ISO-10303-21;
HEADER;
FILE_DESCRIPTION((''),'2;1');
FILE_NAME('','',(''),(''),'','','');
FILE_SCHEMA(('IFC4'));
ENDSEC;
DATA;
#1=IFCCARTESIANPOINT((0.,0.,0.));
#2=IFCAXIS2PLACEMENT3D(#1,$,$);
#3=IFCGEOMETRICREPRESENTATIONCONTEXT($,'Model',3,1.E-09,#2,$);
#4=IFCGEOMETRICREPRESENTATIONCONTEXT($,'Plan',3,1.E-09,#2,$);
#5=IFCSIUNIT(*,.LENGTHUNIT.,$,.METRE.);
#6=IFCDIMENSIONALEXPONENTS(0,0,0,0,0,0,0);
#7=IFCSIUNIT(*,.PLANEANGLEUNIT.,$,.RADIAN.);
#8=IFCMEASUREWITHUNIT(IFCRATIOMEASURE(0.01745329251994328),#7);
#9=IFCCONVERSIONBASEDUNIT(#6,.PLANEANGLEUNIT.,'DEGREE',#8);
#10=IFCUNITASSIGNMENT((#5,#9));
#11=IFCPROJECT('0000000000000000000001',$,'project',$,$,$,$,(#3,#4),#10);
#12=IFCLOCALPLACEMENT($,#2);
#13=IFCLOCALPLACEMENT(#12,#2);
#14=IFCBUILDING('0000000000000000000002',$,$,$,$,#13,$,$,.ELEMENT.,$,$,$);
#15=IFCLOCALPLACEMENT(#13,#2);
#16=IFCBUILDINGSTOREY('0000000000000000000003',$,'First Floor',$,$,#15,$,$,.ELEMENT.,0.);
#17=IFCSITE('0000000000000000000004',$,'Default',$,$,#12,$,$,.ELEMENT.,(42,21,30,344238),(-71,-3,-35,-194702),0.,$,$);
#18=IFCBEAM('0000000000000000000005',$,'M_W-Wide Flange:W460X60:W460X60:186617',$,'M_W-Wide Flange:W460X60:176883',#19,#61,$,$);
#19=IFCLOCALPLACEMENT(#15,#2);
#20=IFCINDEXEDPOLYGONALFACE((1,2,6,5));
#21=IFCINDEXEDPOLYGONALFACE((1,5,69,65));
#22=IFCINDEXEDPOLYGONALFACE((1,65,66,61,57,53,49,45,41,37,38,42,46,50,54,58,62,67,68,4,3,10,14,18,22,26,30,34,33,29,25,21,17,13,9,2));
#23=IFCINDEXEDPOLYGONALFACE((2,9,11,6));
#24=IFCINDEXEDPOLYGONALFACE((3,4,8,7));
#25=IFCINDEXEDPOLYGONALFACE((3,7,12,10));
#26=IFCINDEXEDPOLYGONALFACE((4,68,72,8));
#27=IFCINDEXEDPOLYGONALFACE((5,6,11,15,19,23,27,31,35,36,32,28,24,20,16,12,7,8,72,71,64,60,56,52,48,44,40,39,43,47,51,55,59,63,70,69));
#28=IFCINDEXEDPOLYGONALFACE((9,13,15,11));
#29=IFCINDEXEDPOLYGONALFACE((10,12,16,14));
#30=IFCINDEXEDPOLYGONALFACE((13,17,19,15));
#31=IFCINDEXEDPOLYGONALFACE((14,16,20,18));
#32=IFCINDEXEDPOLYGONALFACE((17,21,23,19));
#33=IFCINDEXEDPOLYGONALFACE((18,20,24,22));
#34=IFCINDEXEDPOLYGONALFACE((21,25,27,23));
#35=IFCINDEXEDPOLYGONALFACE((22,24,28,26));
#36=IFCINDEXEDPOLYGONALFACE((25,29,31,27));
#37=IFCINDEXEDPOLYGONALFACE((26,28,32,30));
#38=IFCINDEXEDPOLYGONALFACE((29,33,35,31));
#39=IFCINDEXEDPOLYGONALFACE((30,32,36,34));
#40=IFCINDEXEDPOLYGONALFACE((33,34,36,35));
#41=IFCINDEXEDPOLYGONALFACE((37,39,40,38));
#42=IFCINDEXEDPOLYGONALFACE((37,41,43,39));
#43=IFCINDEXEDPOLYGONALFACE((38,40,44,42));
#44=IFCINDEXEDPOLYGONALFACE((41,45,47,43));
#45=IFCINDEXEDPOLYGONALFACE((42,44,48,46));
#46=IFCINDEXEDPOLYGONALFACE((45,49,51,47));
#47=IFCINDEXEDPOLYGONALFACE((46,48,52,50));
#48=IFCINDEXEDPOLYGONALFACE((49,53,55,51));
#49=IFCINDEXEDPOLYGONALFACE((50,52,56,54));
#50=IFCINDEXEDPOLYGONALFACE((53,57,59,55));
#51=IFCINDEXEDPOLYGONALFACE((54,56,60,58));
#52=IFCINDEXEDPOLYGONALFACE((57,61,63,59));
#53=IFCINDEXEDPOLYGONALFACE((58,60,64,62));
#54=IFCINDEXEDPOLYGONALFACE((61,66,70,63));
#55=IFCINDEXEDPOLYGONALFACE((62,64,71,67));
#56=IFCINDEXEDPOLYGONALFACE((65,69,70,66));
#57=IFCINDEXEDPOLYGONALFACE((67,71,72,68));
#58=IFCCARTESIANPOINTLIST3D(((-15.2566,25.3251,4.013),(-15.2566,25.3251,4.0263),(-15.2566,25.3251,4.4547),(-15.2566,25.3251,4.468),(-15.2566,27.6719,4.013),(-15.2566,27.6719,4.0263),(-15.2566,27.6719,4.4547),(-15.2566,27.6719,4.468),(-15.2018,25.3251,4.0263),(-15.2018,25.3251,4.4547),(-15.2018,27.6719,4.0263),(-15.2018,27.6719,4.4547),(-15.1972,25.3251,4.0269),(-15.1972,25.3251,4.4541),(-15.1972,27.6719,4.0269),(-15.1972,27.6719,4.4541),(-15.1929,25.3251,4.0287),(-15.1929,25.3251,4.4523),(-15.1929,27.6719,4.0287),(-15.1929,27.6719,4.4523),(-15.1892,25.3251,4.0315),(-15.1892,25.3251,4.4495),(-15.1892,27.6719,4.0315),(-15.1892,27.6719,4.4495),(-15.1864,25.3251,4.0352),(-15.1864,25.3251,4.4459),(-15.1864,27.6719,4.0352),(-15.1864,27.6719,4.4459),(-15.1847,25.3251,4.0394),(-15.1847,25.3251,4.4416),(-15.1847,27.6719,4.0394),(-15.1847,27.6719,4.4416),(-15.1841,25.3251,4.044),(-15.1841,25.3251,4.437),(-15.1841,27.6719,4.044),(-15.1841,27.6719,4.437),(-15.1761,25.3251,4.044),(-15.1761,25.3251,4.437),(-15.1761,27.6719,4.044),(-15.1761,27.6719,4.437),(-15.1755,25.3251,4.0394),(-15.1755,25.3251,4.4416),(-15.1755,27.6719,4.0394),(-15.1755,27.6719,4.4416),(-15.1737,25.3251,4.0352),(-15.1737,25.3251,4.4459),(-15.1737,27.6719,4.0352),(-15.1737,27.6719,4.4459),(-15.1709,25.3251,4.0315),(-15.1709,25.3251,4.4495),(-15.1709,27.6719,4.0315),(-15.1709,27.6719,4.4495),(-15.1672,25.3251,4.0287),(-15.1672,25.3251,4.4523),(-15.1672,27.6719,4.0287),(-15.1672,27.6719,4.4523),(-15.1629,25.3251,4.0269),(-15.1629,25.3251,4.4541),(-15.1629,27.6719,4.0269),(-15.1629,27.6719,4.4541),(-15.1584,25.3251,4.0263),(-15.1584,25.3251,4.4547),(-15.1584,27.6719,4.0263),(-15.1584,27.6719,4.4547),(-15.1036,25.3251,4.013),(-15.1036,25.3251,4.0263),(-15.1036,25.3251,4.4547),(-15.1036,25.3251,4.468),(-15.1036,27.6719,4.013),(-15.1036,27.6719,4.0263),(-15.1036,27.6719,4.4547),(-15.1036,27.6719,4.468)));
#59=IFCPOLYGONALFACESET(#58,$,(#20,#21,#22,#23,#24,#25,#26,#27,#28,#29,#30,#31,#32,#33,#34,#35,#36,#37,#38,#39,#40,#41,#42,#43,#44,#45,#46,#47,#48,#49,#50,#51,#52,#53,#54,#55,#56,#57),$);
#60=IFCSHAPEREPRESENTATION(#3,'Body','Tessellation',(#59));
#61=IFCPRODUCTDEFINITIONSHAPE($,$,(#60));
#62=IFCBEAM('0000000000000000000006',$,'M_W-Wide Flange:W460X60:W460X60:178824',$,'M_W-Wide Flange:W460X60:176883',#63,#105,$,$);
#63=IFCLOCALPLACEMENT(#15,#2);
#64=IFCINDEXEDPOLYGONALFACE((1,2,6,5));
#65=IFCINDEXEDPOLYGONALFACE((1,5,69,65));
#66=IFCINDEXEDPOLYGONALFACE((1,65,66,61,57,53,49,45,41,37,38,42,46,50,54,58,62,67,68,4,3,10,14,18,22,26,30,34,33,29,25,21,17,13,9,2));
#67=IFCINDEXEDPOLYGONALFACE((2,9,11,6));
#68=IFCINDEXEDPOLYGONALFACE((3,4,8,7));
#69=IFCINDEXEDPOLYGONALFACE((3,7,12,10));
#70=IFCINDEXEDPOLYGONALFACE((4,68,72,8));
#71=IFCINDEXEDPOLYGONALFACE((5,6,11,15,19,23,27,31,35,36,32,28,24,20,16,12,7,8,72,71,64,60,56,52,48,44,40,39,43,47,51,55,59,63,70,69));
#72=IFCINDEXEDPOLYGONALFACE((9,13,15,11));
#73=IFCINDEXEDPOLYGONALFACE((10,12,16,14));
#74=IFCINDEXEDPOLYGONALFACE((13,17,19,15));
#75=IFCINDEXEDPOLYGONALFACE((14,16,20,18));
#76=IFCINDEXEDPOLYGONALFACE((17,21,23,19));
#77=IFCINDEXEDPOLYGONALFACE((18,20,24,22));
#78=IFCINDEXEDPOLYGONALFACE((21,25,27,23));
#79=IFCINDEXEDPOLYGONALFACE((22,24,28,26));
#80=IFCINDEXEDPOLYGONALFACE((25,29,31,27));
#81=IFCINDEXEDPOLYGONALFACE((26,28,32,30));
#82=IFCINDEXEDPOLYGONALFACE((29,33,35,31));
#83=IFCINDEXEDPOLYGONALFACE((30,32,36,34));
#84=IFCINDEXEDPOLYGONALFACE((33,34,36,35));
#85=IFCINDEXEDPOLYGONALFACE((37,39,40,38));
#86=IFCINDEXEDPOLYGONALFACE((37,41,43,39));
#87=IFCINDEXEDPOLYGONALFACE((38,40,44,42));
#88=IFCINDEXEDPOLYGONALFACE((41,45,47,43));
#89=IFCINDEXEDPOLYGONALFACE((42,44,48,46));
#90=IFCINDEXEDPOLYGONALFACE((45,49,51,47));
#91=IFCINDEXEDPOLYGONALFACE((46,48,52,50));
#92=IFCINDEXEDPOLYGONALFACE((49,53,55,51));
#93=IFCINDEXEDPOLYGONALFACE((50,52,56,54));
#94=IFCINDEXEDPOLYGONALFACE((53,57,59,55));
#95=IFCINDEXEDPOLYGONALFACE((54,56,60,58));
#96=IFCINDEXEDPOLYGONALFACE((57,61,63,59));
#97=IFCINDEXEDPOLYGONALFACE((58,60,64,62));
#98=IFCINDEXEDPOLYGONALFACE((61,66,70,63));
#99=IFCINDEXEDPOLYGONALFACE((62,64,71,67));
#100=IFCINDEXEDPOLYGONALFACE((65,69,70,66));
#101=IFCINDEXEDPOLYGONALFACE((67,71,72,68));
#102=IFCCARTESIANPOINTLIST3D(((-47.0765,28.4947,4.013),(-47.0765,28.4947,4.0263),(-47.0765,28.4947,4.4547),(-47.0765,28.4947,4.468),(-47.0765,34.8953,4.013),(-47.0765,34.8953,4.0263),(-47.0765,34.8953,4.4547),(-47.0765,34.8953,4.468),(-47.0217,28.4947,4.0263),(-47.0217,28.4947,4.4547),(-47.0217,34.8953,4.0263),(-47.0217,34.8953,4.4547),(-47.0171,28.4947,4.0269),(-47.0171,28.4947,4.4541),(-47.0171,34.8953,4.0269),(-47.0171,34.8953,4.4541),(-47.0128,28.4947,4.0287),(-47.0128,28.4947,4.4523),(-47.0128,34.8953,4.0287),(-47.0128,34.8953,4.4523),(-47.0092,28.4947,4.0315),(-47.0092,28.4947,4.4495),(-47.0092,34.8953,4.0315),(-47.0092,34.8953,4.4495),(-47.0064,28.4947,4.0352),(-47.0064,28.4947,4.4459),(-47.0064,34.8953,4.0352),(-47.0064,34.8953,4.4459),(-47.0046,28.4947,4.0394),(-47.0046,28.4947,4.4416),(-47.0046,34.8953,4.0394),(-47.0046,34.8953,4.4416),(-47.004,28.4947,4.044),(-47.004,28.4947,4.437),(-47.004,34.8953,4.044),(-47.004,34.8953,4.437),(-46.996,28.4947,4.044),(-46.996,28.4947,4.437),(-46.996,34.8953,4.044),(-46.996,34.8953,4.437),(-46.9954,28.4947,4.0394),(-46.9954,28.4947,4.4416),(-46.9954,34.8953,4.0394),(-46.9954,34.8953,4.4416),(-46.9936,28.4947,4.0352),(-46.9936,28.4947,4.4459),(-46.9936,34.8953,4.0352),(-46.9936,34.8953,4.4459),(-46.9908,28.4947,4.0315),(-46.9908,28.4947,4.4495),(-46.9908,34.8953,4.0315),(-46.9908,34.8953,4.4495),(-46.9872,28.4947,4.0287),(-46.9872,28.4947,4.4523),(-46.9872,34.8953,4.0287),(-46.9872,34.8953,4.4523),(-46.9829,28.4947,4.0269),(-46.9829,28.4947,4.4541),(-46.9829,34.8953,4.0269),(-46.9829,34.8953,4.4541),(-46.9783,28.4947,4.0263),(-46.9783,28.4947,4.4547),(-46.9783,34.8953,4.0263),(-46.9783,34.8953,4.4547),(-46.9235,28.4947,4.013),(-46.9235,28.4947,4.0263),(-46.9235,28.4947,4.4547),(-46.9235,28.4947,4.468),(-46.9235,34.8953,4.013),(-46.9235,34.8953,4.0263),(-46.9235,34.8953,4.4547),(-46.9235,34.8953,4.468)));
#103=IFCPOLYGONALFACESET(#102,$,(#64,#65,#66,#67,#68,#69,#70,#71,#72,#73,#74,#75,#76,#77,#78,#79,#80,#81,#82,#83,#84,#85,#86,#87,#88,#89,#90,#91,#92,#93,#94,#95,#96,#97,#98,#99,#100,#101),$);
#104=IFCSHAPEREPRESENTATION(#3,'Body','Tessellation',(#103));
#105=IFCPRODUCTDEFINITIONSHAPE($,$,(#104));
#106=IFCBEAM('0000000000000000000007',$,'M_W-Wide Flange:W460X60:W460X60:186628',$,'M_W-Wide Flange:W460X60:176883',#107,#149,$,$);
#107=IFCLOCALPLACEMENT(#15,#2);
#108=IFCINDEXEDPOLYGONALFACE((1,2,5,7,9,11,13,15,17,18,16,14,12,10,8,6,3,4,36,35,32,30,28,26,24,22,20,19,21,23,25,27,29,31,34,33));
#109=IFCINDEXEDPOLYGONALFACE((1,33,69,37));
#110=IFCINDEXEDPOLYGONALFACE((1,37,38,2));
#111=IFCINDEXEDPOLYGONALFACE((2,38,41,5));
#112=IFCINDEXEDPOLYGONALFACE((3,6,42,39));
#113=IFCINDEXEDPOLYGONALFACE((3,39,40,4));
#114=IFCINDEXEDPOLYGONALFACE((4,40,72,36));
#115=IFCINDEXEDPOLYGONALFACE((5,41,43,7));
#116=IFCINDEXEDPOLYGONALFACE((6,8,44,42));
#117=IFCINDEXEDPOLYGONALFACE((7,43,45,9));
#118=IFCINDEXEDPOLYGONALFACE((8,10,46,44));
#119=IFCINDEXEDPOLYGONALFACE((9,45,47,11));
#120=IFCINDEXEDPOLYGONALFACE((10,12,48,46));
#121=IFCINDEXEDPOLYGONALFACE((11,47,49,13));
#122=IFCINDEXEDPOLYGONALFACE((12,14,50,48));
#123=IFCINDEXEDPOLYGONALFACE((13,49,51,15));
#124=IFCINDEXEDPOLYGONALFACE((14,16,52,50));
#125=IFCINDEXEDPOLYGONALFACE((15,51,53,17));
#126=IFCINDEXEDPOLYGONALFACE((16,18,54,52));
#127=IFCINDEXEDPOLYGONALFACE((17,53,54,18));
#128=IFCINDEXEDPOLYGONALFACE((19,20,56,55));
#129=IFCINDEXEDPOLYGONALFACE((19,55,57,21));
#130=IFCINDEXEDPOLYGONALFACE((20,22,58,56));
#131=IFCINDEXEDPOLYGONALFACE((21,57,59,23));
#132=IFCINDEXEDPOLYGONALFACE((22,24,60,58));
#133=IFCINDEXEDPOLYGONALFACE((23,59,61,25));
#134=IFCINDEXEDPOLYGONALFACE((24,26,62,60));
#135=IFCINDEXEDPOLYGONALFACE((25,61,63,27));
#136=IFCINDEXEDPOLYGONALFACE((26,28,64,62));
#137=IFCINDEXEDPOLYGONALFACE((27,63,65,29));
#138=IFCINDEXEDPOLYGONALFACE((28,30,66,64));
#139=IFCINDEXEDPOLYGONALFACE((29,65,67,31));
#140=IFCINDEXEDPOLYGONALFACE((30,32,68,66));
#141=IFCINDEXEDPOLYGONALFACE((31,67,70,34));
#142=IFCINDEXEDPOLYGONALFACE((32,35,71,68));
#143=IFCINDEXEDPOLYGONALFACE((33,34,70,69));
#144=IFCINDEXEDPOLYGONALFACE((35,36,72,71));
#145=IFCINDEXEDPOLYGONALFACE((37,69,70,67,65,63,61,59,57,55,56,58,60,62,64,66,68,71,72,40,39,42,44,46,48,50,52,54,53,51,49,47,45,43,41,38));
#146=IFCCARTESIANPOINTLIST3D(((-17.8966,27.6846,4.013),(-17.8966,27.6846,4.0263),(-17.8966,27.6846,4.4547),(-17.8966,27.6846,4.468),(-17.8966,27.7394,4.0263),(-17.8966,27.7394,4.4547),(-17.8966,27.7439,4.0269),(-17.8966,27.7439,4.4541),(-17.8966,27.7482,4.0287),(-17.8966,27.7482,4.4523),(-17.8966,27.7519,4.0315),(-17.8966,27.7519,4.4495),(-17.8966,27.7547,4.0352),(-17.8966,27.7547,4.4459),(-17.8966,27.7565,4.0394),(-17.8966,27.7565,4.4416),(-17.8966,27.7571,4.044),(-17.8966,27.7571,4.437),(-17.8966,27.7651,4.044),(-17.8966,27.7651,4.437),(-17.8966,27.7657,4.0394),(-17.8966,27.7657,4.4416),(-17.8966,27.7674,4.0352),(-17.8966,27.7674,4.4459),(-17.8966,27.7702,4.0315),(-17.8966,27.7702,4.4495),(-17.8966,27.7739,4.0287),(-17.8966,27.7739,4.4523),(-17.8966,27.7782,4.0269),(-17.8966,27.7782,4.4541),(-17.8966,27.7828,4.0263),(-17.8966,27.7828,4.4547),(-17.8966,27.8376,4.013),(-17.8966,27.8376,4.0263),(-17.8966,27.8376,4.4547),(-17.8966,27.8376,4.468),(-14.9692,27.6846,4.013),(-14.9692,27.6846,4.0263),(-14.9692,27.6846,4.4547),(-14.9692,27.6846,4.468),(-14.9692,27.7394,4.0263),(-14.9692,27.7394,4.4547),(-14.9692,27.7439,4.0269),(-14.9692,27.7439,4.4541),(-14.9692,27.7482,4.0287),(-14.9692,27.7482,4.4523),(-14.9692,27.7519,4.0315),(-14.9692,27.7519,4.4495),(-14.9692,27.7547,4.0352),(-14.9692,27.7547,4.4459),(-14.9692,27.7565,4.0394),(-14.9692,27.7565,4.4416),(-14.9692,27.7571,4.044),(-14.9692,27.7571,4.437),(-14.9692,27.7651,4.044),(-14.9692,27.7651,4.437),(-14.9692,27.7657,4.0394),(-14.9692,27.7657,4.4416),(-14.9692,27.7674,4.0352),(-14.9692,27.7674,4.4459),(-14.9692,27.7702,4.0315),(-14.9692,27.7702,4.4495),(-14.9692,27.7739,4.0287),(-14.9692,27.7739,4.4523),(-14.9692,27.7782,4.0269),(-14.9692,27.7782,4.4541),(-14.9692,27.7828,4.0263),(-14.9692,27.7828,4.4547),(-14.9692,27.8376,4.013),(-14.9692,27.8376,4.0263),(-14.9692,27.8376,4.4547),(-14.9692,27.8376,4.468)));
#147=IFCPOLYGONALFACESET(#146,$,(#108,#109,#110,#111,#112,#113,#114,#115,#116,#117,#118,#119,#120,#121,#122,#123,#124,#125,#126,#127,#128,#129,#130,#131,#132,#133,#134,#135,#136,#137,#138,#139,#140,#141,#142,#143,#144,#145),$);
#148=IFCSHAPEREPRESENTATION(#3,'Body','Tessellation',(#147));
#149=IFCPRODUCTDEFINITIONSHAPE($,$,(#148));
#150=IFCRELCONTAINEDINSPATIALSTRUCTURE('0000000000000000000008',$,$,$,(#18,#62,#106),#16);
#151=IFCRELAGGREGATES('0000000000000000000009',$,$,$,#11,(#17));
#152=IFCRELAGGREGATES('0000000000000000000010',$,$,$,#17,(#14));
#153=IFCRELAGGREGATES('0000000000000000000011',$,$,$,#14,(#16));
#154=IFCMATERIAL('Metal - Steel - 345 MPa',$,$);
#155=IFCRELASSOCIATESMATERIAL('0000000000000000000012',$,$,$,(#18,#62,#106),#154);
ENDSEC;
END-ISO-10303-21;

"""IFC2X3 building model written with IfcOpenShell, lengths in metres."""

from ifc_helpers import new_model, entity, si_unit, converted_unit, frame, frame_2d, origin, place, context, project, spatial, polyline, circle_curve, parameter, trimmed, segment, composite_curve, outline, extrude, material, element, save


model = new_model("IFC2X3")

# Units and contexts
model_context = context("Model", 3, precision=1e-09, world=origin())
plan_context = context("Plan", 3, precision=1e-09, world=origin())
ifc_project = project(units=[si_unit("LENGTHUNIT", "METRE"), converted_unit("PLANEANGLEUNIT", "DEGREE", entity("IfcRatioMeasure", 0.01745329251994328), si_unit("PLANEANGLEUNIT", "RADIAN"), dimensions=[0, 0, 0, 0, 0, 0, 0])], contexts=[model_context, plan_context])

# Site, building, storey
site_placement = place(None, origin())
site = spatial("IfcSite", under=ifc_project, at=site_placement, Name="Default", CompositionType="ELEMENT", RefLatitude=(42, 21, 30, 344238), RefLongitude=(-71, -3, -35, -194702), RefElevation=0.0)
building_placement = place(site_placement, origin())
building = spatial("IfcBuilding", under=site, at=building_placement, CompositionType="ELEMENT")
storey_placement = place(building_placement, origin())
storey = spatial("IfcBuildingStorey", under=building, at=storey_placement, Name="First Floor", CompositionType="ELEMENT", Elevation=0.0)

# Beams
ifc_material_1 = material(Name="Metal - Steel - 345 MPa")
beam_1_placement = place(storey_placement, frame((-15.1801, 27.6649, 4.468), z_axis=(0.0, 0.0, 1.0), x_axis=(-1.0, 0.0, 0.0)))
element("IfcBeam", 1, at=beam_1_placement, inside=storey, material=ifc_material_1, Name="M_W-Wide Flange:W460X60:W460X60:186617", ObjectType="M_W-Wide Flange:W460X60:176883", context=model_context, shape_type="SweptSolid", body=[
    extrude(outline(composite_curve([segment(polyline([(0.2142, -0.0765), (0.2275, -0.0765)]), True, "CONTINUOUS"), segment(polyline([(0.2275, -0.0765), (0.2275, 0.0765)]), True, "CONTINUOUS"), segment(polyline([(0.2275, 0.0765), (0.2142, 0.0765)]), True, "CONTINUOUS"), segment(polyline([(0.2142, 0.0765), (0.2142, 0.0217)]), True, "CONTINUOUS"), segment(trimmed(circle_curve(frame_2d((0.1965, 0.0217), x_axis=(0.0, 1.0)), 0.0177), [parameter(180.0)], [parameter(270.0)], True, "PARAMETER"), False, "CONTINUOUS"), segment(polyline([(0.1965, 0.004), (-0.1965, 0.004)]), True, "CONTINUOUS"), segment(trimmed(circle_curve(frame_2d((-0.1965, 0.0217), x_axis=(0.0, 1.0)), 0.0177), [parameter(90.0)], [parameter(180.0)], True, "PARAMETER"), False, "CONTINUOUS"), segment(polyline([(-0.2142, 0.0217), (-0.2142, 0.0765)]), True, "CONTINUOUS"), segment(polyline([(-0.2142, 0.0765), (-0.2275, 0.0765)]), True, "CONTINUOUS"), segment(polyline([(-0.2275, 0.0765), (-0.2275, -0.0765)]), True, "CONTINUOUS"), segment(polyline([(-0.2275, -0.0765), (-0.2142, -0.0765)]), True, "CONTINUOUS"), segment(polyline([(-0.2142, -0.0765), (-0.2142, -0.0217)]), True, "CONTINUOUS"), segment(trimmed(circle_curve(frame_2d((-0.1965, -0.0217), x_axis=(0.0, 1.0)), 0.0177), [parameter(360.0)], [parameter(90.0)], True, "PARAMETER"), False, "CONTINUOUS"), segment(polyline([(-0.1965, -0.004), (0.1965, -0.004)]), True, "CONTINUOUS"), segment(trimmed(circle_curve(frame_2d((0.1965, -0.0217), x_axis=(0.0, 1.0)), 0.0177), [parameter(270.0)], [parameter(0.0)], True, "PARAMETER"), False, "CONTINUOUS"), segment(polyline([(0.2142, -0.0217), (0.2142, -0.0765)]), True, "CONTINUOUS")], self_intersect=False)), frame((0.0, 2.3399, -0.2275), z_axis=(0.0, -1.0, 0.0), x_axis=(0.0, 0.0, -1.0)), (0.0, 0.0, 1.0), 2.3468),
])
beam_2_placement = place(storey_placement, frame((-47.0, 28.3779, 4.468)))
element("IfcBeam", 2, at=beam_2_placement, inside=storey, material=ifc_material_1, Name="M_W-Wide Flange:W460X60:W460X60:178824", ObjectType="M_W-Wide Flange:W460X60:176883", context=model_context, shape_type="SweptSolid", body=[
    extrude(outline(composite_curve([segment(polyline([(-0.0765, -0.2142), (-0.0765, -0.2275)]), True, "CONTINUOUS"), segment(polyline([(-0.0765, -0.2275), (0.0765, -0.2275)]), True, "CONTINUOUS"), segment(polyline([(0.0765, -0.2275), (0.0765, -0.2142)]), True, "CONTINUOUS"), segment(polyline([(0.0765, -0.2142), (0.0217, -0.2142)]), True, "CONTINUOUS"), segment(trimmed(circle_curve(frame_2d((0.0217, -0.1965), x_axis=(0.0, -1.0)), 0.0177), [parameter(270.0)], [parameter(360.0)], True, "PARAMETER"), False, "CONTINUOUS"), segment(polyline([(0.004, -0.1965), (0.004, 0.1965)]), True, "CONTINUOUS"), segment(trimmed(circle_curve(frame_2d((0.0217, 0.1965), x_axis=(-1.0, 0.0)), 0.0177), [parameter(270.0)], [parameter(360.0)], True, "PARAMETER"), False, "CONTINUOUS"), segment(polyline([(0.0217, 0.2142), (0.0765, 0.2142)]), True, "CONTINUOUS"), segment(polyline([(0.0765, 0.2142), (0.0765, 0.2275)]), True, "CONTINUOUS"), segment(polyline([(0.0765, 0.2275), (-0.0765, 0.2275)]), True, "CONTINUOUS"), segment(polyline([(-0.0765, 0.2275), (-0.0765, 0.2142)]), True, "CONTINUOUS"), segment(polyline([(-0.0765, 0.2142), (-0.0217, 0.2142)]), True, "CONTINUOUS"), segment(trimmed(circle_curve(frame_2d((-0.0217, 0.1965), x_axis=(0.0, 1.0)), 0.0177), [parameter(270.0)], [parameter(360.0)], True, "PARAMETER"), False, "CONTINUOUS"), segment(polyline([(-0.004, 0.1965), (-0.004, -0.1965)]), True, "CONTINUOUS"), segment(trimmed(circle_curve(frame_2d((-0.0217, -0.1965), x_axis=(1.0, 0.0)), 0.0177), [parameter(270.0)], [parameter(0.0)], True, "PARAMETER"), False, "CONTINUOUS"), segment(polyline([(-0.0217, -0.2142), (-0.0765, -0.2142)]), True, "CONTINUOUS")], self_intersect=False)), frame((0.0, 0.1168, -0.2275), z_axis=(0.0, -1.0, 0.0), x_axis=(1.0, 0.0, 0.0)), (0.0, 0.0, -1.0), 6.4006),
])
beam_3_placement = place(storey_placement, frame((-17.8481, 27.7611, 4.468), z_axis=(0.0, 0.0, 1.0), x_axis=(0.0, -1.0, 0.0)))
element("IfcBeam", 3, at=beam_3_placement, inside=storey, material=ifc_material_1, Name="M_W-Wide Flange:W460X60:W460X60:186628", ObjectType="M_W-Wide Flange:W460X60:176883", context=model_context, shape_type="SweptSolid", body=[
    extrude(outline(composite_curve([segment(polyline([(-0.0765, -0.2142), (-0.0765, -0.2275)]), True, "CONTINUOUS"), segment(polyline([(-0.0765, -0.2275), (0.0765, -0.2275)]), True, "CONTINUOUS"), segment(polyline([(0.0765, -0.2275), (0.0765, -0.2142)]), True, "CONTINUOUS"), segment(polyline([(0.0765, -0.2142), (0.0217, -0.2142)]), True, "CONTINUOUS"), segment(trimmed(circle_curve(frame_2d((0.0217, -0.1965), x_axis=(1.0, 0.0)), 0.0177), [parameter(180.0)], [parameter(270.0)], True, "PARAMETER"), False, "CONTINUOUS"), segment(polyline([(0.004, -0.1965), (0.004, 0.1965)]), True, "CONTINUOUS"), segment(trimmed(circle_curve(frame_2d((0.0217, 0.1965), x_axis=(1.0, 0.0)), 0.0177), [parameter(90.0)], [parameter(180.0)], True, "PARAMETER"), False, "CONTINUOUS"), segment(polyline([(0.0217, 0.2142), (0.0765, 0.2142)]), True, "CONTINUOUS"), segment(polyline([(0.0765, 0.2142), (0.0765, 0.2275)]), True, "CONTINUOUS"), segment(polyline([(0.0765, 0.2275), (-0.0765, 0.2275)]), True, "CONTINUOUS"), segment(polyline([(-0.0765, 0.2275), (-0.0765, 0.2142)]), True, "CONTINUOUS"), segment(polyline([(-0.0765, 0.2142), (-0.0217, 0.2142)]), True, "CONTINUOUS"), segment(trimmed(circle_curve(frame_2d((-0.0217, 0.1965), x_axis=(1.0, 0.0)), 0.0177), [parameter(360.0)], [parameter(90.0)], True, "PARAMETER"), False, "CONTINUOUS"), segment(polyline([(-0.004, 0.1965), (-0.004, -0.1965)]), True, "CONTINUOUS"), segment(trimmed(circle_curve(frame_2d((-0.0217, -0.1965), x_axis=(1.0, 0.0)), 0.0177), [parameter(270.0)], [parameter(0.0)], True, "PARAMETER"), False, "CONTINUOUS"), segment(polyline([(-0.0217, -0.2142), (-0.0765, -0.2142)]), True, "CONTINUOUS")], self_intersect=False)), frame((0.0, -0.0485, -0.2275), z_axis=(0.0, -1.0, 0.0), x_axis=(1.0, 0.0, 0.0)), (0.0, 0.0, -1.0), 2.9274),
])

save(model, "model.ifc")
